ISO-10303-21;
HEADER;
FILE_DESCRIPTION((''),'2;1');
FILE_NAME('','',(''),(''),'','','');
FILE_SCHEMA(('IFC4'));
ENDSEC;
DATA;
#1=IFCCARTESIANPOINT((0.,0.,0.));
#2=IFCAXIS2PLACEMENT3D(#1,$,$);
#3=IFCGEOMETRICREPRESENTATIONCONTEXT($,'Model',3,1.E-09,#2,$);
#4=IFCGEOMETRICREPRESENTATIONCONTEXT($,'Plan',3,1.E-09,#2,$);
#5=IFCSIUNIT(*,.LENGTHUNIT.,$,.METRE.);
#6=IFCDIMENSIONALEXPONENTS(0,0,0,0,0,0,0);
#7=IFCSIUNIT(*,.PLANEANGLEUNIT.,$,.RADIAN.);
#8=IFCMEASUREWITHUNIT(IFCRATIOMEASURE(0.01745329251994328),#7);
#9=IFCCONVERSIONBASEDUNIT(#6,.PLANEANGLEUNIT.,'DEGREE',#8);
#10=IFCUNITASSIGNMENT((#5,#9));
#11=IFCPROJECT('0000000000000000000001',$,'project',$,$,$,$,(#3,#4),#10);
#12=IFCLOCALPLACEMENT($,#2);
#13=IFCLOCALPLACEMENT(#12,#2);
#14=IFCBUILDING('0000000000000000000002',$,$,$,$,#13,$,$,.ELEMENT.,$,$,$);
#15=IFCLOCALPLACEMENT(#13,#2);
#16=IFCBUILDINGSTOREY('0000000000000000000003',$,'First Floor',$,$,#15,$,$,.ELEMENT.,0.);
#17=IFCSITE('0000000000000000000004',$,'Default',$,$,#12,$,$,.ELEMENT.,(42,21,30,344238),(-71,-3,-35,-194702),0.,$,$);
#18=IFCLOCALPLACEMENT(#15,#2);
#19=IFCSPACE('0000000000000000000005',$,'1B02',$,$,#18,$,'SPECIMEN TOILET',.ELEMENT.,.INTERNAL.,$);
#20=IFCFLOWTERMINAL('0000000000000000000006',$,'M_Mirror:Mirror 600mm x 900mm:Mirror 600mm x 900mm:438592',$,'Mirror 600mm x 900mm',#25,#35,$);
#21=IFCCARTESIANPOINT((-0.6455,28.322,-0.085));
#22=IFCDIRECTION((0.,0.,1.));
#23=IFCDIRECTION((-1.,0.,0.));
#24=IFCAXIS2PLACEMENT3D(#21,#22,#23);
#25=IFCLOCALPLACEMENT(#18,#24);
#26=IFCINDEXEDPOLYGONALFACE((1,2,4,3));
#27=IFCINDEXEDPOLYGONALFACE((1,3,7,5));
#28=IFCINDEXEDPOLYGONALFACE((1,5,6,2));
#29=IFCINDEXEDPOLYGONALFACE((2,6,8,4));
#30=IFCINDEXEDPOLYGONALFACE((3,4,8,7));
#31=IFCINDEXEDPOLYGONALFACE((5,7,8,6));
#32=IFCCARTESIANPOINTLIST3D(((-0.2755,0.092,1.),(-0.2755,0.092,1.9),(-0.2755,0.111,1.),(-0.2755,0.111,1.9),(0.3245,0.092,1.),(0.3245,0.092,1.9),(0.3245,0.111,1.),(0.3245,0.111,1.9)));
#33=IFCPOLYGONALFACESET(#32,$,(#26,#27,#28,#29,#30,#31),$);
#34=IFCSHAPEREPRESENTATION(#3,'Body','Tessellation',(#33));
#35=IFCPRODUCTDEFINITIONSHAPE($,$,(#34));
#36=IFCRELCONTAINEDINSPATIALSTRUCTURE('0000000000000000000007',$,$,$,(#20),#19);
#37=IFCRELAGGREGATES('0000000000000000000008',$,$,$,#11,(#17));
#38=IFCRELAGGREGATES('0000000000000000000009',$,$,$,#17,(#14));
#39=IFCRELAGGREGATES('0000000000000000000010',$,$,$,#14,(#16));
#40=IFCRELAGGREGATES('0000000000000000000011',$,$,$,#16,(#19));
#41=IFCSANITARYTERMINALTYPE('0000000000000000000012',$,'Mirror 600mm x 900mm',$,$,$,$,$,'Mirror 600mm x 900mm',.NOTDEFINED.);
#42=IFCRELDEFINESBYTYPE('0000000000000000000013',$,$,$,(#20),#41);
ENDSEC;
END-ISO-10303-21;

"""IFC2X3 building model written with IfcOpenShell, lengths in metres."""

from ifc_helpers import new_model, entity, si_unit, converted_unit, frame, origin, origin_2d_with_axis, place, context, project, spatial, rectangle, extrude, source, transform, mapped, type_object, type_shapes, element, save


model = new_model("IFC2X3")

# Units and contexts
model_context = context("Model", 3, precision=1e-09, world=origin())
plan_context = context("Plan", 3, precision=1e-09, world=origin())
ifc_project = project(units=[si_unit("LENGTHUNIT", "METRE"), converted_unit("PLANEANGLEUNIT", "DEGREE", entity("IfcRatioMeasure", 0.01745329251994328), si_unit("PLANEANGLEUNIT", "RADIAN"), dimensions=[0, 0, 0, 0, 0, 0, 0])], contexts=[model_context, plan_context])

# Site, building, storey
site_placement = place(None, origin())
site = spatial("IfcSite", under=ifc_project, at=site_placement, Name="Default", CompositionType="ELEMENT", RefLatitude=(42, 21, 30, 344238), RefLongitude=(-71, -3, -35, -194702), RefElevation=0.0)
building_placement = place(site_placement, origin())
building = spatial("IfcBuilding", under=site, at=building_placement, CompositionType="ELEMENT")
storey_placement = place(building_placement, origin())
storey = spatial("IfcBuildingStorey", under=building, at=storey_placement, Name="First Floor", CompositionType="ELEMENT", Elevation=0.0)

# Shared definitions
space_1_placement = place(storey_placement, origin())
space_1 = spatial("IfcSpace", under=storey, at=space_1_placement, Name="1B02", LongName="SPECIMEN TOILET", CompositionType="ELEMENT", InteriorOrExteriorSpace="INTERNAL")

# Flow terminal
sanitary_terminal_type = type_object("IfcSanitaryTerminalType", Name="Mirror 600mm x 900mm", ElementType="Mirror 600mm x 900mm", PredefinedType="NOTDEFINED")
shared_shape_1 = source(origin(), model_context, "Body", "SweptSolid", [
    extrude(rectangle(XDim=0.0191, YDim=0.6, at=origin_2d_with_axis()), frame((0.0245, 0.1015, 1.0), z_axis=(0.0, 0.0, 1.0), x_axis=(0.0, -1.0, 0.0)), (0.0, 0.0, 1.0), 0.9),
])
type_shapes(sanitary_terminal_type, [shared_shape_1])
flow_terminal_placement = place(space_1_placement, frame((-0.6455, 28.322, -0.085), z_axis=(0.0, 0.0, 1.0), x_axis=(-1.0, 0.0, 0.0)))
element("IfcFlowTerminal", 1, at=flow_terminal_placement, inside=space_1, type_object=sanitary_terminal_type, Name="M_Mirror:Mirror 600mm x 900mm:Mirror 600mm x 900mm:438592", ObjectType="Mirror 600mm x 900mm", context=model_context, shape_type="MappedRepresentation", body=[
    mapped(shared_shape_1, transform((0.0, 0.0, 0.0), scale=1.0)),
])

save(model, "model.ifc")
